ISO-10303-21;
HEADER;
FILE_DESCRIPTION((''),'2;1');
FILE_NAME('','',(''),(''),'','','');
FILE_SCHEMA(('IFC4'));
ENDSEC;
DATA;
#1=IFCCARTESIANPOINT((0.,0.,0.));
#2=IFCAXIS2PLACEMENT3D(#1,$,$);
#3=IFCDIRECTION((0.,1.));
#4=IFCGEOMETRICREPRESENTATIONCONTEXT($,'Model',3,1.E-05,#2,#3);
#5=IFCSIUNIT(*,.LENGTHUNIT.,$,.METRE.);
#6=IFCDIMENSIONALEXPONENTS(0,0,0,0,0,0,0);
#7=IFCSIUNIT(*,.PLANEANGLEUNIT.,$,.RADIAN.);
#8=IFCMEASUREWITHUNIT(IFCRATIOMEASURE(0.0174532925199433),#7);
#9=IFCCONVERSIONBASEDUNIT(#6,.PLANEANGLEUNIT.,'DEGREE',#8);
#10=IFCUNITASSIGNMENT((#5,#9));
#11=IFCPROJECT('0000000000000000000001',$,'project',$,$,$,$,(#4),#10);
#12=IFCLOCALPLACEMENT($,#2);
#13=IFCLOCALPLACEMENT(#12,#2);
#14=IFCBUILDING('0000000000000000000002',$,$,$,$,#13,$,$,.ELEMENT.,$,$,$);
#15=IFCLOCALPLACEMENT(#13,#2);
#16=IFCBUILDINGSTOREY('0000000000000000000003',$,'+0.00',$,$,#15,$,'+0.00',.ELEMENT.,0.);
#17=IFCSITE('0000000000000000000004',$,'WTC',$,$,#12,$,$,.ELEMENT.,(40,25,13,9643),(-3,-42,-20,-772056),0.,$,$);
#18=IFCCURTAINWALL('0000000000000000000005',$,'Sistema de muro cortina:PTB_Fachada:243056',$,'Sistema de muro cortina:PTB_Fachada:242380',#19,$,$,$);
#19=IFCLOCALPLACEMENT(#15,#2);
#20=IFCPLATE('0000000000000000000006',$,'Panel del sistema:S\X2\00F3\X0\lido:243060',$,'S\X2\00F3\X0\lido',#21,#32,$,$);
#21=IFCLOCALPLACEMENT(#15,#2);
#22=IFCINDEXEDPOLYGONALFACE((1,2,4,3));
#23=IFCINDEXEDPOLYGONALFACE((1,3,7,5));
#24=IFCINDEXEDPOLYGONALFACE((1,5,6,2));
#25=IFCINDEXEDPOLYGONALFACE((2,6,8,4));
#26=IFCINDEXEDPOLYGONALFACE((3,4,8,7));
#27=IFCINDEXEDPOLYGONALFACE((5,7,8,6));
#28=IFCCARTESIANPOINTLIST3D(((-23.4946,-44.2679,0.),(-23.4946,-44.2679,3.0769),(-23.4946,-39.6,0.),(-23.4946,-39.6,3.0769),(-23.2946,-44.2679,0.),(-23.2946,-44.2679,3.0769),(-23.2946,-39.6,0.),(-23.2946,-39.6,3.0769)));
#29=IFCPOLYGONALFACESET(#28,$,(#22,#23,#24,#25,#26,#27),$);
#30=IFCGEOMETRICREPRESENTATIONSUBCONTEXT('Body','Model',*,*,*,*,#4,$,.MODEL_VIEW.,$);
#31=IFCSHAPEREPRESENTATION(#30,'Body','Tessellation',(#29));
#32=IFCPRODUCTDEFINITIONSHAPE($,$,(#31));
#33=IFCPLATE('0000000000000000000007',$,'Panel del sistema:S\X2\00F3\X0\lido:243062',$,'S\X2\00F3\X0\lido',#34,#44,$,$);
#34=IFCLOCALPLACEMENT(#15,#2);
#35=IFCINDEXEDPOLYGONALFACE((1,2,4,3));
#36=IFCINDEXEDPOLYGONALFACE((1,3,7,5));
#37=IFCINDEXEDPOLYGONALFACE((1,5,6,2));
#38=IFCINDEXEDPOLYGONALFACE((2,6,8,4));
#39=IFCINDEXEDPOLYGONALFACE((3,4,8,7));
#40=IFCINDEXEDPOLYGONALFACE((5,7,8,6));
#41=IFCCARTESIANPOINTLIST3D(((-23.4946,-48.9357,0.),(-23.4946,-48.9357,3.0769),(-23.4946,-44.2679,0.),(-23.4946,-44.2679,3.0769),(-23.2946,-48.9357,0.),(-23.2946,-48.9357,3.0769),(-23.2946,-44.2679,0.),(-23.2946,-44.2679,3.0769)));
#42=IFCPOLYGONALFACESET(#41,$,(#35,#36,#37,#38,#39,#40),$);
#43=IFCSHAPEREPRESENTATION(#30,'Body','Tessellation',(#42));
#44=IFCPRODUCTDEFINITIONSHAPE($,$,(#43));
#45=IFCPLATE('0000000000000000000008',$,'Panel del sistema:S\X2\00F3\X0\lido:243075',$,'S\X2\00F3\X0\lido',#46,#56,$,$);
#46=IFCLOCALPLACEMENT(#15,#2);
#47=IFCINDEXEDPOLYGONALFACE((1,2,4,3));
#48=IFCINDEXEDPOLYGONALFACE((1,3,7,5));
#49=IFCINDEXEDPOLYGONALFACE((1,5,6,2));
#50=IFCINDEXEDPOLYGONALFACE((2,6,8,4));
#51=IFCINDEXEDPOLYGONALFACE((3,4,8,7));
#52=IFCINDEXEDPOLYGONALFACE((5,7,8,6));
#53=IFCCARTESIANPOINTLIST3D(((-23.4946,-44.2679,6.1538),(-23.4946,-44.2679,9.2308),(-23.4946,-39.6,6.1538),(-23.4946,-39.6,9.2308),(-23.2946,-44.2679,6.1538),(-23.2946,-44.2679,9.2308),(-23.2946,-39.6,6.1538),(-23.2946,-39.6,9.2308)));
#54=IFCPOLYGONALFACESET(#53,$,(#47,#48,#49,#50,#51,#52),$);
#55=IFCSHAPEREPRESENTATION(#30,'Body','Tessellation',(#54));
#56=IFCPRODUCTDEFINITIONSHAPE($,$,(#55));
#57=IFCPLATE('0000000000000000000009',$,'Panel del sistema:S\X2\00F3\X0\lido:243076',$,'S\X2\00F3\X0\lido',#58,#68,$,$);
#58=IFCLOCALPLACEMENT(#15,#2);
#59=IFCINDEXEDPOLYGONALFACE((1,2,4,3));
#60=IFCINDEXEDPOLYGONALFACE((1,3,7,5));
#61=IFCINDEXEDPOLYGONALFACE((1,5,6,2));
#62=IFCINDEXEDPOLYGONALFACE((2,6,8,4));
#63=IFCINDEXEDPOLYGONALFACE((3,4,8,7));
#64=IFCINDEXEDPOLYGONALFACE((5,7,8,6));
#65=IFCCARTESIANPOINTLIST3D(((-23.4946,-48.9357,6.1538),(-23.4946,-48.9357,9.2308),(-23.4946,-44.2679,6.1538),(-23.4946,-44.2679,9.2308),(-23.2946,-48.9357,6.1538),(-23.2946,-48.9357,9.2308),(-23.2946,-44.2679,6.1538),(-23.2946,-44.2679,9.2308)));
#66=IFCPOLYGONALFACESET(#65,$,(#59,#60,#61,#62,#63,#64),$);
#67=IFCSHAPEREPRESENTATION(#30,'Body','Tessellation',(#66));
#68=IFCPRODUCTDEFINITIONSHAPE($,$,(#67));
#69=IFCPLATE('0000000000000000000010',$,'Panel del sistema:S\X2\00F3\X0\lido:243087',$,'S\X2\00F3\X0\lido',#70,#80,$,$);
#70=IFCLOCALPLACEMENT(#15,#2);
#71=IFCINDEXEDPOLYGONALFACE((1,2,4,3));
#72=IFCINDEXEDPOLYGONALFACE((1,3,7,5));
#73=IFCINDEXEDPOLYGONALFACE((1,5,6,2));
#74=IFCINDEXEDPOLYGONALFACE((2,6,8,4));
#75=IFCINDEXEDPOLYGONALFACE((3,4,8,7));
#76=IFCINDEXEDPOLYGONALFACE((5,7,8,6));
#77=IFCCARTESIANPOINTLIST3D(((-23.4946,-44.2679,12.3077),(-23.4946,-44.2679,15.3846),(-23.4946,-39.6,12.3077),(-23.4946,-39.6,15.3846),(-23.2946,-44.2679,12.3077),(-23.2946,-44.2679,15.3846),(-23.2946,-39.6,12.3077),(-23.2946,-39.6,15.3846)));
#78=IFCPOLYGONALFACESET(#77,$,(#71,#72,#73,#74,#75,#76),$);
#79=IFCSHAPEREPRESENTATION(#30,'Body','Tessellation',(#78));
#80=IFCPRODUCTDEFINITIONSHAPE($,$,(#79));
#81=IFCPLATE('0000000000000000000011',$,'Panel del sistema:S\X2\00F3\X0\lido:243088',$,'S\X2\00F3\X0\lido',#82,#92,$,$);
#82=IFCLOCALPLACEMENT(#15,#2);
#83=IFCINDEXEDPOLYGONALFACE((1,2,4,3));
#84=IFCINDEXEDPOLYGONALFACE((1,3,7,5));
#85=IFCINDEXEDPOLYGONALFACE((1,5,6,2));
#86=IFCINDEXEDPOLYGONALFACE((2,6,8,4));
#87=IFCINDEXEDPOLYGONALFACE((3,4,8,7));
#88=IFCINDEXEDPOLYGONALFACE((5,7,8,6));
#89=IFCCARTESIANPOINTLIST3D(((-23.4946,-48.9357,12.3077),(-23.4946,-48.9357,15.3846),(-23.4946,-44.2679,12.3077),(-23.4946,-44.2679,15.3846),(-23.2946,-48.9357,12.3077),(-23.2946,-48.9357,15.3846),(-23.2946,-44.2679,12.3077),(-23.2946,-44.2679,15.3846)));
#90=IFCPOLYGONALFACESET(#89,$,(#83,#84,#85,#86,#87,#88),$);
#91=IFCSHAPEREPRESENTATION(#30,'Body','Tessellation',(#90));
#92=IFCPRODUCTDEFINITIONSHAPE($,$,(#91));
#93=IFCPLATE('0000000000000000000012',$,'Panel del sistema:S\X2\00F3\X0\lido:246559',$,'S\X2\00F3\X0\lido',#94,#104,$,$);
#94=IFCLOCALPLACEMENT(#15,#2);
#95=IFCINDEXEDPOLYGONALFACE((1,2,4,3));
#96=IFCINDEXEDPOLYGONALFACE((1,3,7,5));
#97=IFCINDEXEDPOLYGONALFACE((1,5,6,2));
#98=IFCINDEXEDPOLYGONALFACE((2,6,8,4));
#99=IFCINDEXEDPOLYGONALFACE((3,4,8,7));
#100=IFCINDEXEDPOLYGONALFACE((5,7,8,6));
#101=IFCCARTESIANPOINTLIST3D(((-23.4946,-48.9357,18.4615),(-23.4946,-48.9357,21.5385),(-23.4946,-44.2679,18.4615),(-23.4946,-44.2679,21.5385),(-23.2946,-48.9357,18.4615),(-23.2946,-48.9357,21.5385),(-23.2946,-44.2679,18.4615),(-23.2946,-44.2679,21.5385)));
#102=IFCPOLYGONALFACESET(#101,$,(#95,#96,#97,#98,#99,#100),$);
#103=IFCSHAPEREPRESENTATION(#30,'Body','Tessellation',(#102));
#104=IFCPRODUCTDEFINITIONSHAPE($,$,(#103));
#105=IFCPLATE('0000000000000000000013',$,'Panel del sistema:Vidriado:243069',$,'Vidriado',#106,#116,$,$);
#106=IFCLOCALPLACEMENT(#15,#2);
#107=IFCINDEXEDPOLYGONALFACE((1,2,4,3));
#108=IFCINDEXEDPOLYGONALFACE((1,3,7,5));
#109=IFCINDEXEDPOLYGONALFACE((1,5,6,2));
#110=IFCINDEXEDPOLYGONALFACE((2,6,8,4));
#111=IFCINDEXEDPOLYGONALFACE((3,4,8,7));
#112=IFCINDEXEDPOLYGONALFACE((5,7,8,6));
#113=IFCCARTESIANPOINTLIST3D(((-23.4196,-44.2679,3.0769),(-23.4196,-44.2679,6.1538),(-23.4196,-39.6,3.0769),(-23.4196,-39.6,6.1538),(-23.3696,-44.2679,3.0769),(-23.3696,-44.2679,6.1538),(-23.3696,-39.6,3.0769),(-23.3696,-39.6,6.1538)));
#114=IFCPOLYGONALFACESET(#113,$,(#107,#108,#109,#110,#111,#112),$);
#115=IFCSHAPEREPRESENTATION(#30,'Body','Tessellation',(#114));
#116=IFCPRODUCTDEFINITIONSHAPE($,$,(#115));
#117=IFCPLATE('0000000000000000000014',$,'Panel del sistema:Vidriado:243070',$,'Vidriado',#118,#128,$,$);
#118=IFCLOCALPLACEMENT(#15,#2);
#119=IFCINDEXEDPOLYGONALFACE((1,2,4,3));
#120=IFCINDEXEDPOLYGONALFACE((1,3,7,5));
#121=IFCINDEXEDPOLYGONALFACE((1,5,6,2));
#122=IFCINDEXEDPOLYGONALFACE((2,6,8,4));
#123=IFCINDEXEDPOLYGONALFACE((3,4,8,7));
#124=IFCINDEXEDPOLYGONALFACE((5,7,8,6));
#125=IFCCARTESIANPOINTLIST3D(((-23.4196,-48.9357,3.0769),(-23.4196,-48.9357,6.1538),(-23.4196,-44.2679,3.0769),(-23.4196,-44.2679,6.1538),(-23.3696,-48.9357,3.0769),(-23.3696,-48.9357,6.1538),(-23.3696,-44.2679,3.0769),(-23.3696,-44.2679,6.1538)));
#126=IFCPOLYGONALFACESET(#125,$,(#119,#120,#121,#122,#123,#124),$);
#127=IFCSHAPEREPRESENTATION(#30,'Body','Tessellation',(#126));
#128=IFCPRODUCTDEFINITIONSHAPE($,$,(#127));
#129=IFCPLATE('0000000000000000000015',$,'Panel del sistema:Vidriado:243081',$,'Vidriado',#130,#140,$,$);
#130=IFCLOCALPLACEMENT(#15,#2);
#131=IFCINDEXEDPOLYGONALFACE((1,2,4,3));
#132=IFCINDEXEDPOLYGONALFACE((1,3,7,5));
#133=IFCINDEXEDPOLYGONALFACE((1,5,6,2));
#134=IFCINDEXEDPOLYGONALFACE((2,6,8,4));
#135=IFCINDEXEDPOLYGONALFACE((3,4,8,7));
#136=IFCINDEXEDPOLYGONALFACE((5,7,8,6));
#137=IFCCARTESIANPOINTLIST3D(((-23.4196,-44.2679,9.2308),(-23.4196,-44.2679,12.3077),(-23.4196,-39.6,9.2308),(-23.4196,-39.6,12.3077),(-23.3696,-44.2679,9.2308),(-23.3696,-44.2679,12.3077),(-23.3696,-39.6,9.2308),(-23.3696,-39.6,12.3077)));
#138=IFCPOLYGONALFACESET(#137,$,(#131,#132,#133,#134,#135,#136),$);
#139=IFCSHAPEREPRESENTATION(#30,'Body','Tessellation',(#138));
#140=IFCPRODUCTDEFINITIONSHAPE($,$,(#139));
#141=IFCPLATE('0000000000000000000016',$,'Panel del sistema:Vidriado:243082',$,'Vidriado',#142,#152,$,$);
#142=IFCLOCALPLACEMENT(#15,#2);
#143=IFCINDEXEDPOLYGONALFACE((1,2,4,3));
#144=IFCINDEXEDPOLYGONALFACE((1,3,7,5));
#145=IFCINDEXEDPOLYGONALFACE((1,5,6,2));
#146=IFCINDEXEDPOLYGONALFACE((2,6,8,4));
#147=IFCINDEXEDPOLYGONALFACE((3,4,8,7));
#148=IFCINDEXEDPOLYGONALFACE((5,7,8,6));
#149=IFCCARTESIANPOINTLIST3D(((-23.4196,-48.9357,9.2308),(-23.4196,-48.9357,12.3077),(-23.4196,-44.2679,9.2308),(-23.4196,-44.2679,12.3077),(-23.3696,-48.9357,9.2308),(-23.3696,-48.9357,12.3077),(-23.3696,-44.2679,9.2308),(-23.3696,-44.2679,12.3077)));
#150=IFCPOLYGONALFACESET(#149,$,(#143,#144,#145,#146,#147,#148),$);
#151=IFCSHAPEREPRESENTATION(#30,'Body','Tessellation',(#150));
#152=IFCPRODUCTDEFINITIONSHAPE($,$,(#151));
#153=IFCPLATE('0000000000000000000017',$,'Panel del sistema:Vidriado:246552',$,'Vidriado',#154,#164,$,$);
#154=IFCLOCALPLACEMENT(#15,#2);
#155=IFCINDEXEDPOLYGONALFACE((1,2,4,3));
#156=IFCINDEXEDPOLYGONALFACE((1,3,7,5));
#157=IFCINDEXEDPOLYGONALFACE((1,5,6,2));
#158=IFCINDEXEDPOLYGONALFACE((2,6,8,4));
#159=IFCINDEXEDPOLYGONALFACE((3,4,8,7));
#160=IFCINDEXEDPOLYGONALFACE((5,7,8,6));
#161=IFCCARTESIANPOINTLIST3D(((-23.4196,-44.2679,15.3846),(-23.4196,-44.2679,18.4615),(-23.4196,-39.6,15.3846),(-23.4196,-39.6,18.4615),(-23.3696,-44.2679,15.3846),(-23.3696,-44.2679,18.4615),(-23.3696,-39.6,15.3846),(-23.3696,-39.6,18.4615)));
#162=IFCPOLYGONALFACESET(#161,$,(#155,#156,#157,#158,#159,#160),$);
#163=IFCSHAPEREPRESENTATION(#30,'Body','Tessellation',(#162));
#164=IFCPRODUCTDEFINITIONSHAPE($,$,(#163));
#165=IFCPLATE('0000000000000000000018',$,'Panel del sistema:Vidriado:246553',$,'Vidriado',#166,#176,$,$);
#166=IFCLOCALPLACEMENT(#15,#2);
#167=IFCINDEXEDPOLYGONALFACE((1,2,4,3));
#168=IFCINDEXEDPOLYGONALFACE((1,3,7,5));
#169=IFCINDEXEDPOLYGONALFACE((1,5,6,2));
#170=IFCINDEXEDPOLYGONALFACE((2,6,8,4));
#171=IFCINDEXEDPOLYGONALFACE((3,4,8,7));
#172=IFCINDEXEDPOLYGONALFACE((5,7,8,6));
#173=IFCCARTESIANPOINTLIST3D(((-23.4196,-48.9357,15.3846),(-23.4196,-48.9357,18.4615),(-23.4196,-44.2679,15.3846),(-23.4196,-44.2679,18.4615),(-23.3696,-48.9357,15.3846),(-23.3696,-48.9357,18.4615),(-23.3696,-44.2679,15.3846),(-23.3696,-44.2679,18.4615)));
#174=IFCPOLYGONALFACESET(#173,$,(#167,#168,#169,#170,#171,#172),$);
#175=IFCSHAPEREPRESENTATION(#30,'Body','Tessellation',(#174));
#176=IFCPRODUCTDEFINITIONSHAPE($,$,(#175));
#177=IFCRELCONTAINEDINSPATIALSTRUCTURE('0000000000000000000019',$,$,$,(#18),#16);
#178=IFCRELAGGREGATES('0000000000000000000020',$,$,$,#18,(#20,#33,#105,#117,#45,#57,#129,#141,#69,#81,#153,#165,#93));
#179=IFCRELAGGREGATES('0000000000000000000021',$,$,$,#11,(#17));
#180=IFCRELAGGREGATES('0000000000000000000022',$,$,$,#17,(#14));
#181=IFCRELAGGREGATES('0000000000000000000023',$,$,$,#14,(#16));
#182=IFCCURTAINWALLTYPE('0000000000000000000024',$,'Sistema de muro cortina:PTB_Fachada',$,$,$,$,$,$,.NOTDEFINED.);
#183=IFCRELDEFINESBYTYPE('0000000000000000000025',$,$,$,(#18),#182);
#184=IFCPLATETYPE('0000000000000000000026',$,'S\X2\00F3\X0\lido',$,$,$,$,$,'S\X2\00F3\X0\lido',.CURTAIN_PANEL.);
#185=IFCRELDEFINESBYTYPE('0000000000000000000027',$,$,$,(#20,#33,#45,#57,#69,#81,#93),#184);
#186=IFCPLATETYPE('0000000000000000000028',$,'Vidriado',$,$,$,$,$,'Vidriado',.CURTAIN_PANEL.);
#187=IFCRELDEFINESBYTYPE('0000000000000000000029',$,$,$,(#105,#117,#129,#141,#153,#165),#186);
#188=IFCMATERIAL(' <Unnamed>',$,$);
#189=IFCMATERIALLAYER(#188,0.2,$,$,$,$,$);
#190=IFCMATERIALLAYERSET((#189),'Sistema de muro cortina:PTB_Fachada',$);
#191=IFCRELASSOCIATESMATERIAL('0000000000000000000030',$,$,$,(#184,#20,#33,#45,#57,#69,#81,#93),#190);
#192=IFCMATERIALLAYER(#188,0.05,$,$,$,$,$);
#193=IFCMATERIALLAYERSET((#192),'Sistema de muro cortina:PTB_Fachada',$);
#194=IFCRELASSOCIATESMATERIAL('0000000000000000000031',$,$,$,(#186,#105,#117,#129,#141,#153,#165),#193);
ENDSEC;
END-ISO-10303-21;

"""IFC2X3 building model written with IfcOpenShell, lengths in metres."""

from ifc_helpers import new_model, entity, si_unit, converted_unit, direction, frame, origin, origin_2d_with_axis, place, context, subcontext, project, spatial, rectangle, extrude, source, transform, mapped, material, layer, layer_set, layer_usage, type_object, type_shapes, element, aggregate, save


model = new_model("IFC2X3")

# Units and contexts
model_context = context("Model", 3, precision=1e-05, world=origin(), true_north=direction((0.0, 1.0)))
body_context = subcontext(model_context, "Body", "Model", "MODEL_VIEW")
ifc_project = project(units=[si_unit("LENGTHUNIT", "METRE"), converted_unit("PLANEANGLEUNIT", "DEGREE", entity("IfcRatioMeasure", 0.0174532925199433), si_unit("PLANEANGLEUNIT", "RADIAN"), dimensions=[0, 0, 0, 0, 0, 0, 0])], contexts=[model_context])

# Site, building, storey
site_placement = place(None, origin())
site = spatial("IfcSite", under=ifc_project, at=site_placement, Name="WTC", CompositionType="ELEMENT", RefLatitude=(40, 25, 13, 9643), RefLongitude=(-3, -42, -20, -772056), RefElevation=0.0)
building_placement = place(site_placement, origin())
building = spatial("IfcBuilding", under=site, at=building_placement, CompositionType="ELEMENT")
storey_placement = place(building_placement, origin())
storey = spatial("IfcBuildingStorey", under=building, at=storey_placement, Name="+0.00", LongName="+0.00", CompositionType="ELEMENT", Elevation=0.0)

# Curtain wall, plates
curtain_wall_type = type_object("IfcCurtainWallType", Name="Sistema de muro cortina:PTB_Fachada", PredefinedType="NOTDEFINED")
curtain_wall_1_placement = place(storey_placement, origin())
curtain_wall_1 = element("IfcCurtainWall", 1, at=curtain_wall_1_placement, inside=storey, type_object=curtain_wall_type, Name="Sistema de muro cortina:PTB_Fachada:243056", ObjectType="Sistema de muro cortina:PTB_Fachada:242380")
ifc_material = material(Name=" <Unnamed>")
ifc_layer_1 = layer(ifc_material, 0.2)
ifc_layer_set_1 = layer_set([ifc_layer_1], Name="Sistema de muro cortina:PTB_Fachada")
ifc_layer_usage_1 = layer_usage(ifc_layer_set_1, "AXIS3", "POSITIVE", 0.0)
plate_type_1 = type_object("IfcPlateType", Name="Sólido", ElementType="Sólido", PredefinedType="CURTAIN_PANEL", material=ifc_layer_set_1)
shared_shape_1 = source(origin(), body_context, "Body", "SweptSolid", [
    extrude(rectangle(XDim=0.2, YDim=4.6679, at=origin_2d_with_axis()), frame((0.0, 0.0, 0.0), z_axis=(0.0, 0.0, 1.0), x_axis=(0.0, 1.0, 0.0)), (0.0, 0.0, 1.0), 3.0769),
])
type_shapes(plate_type_1, [shared_shape_1])
plate_1_placement = place(curtain_wall_1_placement, frame((-23.3946, -41.9339, 0.0), z_axis=(0.0, 0.0, 1.0), x_axis=(0.0, -1.0, 0.0)))
plate_1 = element("IfcPlate", 2, at=plate_1_placement, type_object=plate_type_1, material=ifc_layer_usage_1, Name="Panel del sistema:Sólido:243060", ObjectType="Sólido", context=body_context, shape_type="MappedRepresentation", body=[
    mapped(shared_shape_1, transform((0.0, 0.0, 0.0), scale=1.0)),
])
ifc_layer_usage_2 = layer_usage(ifc_layer_set_1, "AXIS3", "POSITIVE", 0.0)
plate_2_placement = place(curtain_wall_1_placement, frame((-23.3946, -46.6018, 0.0), z_axis=(0.0, 0.0, 1.0), x_axis=(0.0, -1.0, 0.0)))
plate_2 = element("IfcPlate", 3, at=plate_2_placement, type_object=plate_type_1, material=ifc_layer_usage_2, Name="Panel del sistema:Sólido:243062", ObjectType="Sólido", context=body_context, shape_type="MappedRepresentation", body=[
    mapped(shared_shape_1, transform((0.0, 0.0, 0.0), scale=1.0)),
])
ifc_layer_usage_3 = layer_usage(ifc_layer_set_1, "AXIS3", "POSITIVE", 0.0)
plate_3_placement = place(curtain_wall_1_placement, frame((-23.3946, -41.9339, 6.1538), z_axis=(0.0, 0.0, 1.0), x_axis=(0.0, -1.0, 0.0)))
plate_3 = element("IfcPlate", 4, at=plate_3_placement, type_object=plate_type_1, material=ifc_layer_usage_3, Name="Panel del sistema:Sólido:243075", ObjectType="Sólido", context=body_context, shape_type="MappedRepresentation", body=[
    mapped(shared_shape_1, transform((0.0, 0.0, 0.0), scale=1.0)),
])
ifc_layer_usage_4 = layer_usage(ifc_layer_set_1, "AXIS3", "POSITIVE", 0.0)
plate_4_placement = place(curtain_wall_1_placement, frame((-23.3946, -46.6018, 6.1538), z_axis=(0.0, 0.0, 1.0), x_axis=(0.0, -1.0, 0.0)))
plate_4 = element("IfcPlate", 5, at=plate_4_placement, type_object=plate_type_1, material=ifc_layer_usage_4, Name="Panel del sistema:Sólido:243076", ObjectType="Sólido", context=body_context, shape_type="MappedRepresentation", body=[
    mapped(shared_shape_1, transform((0.0, 0.0, 0.0), scale=1.0)),
])
ifc_layer_usage_5 = layer_usage(ifc_layer_set_1, "AXIS3", "POSITIVE", 0.0)
plate_5_placement = place(curtain_wall_1_placement, frame((-23.3946, -41.9339, 12.3077), z_axis=(0.0, 0.0, 1.0), x_axis=(0.0, -1.0, 0.0)))
plate_5 = element("IfcPlate", 6, at=plate_5_placement, type_object=plate_type_1, material=ifc_layer_usage_5, Name="Panel del sistema:Sólido:243087", ObjectType="Sólido", context=body_context, shape_type="MappedRepresentation", body=[
    mapped(shared_shape_1, transform((0.0, 0.0, 0.0), scale=1.0)),
])
ifc_layer_usage_6 = layer_usage(ifc_layer_set_1, "AXIS3", "POSITIVE", 0.0)
plate_6_placement = place(curtain_wall_1_placement, frame((-23.3946, -46.6018, 12.3077), z_axis=(0.0, 0.0, 1.0), x_axis=(0.0, -1.0, 0.0)))
plate_6 = element("IfcPlate", 7, at=plate_6_placement, type_object=plate_type_1, material=ifc_layer_usage_6, Name="Panel del sistema:Sólido:243088", ObjectType="Sólido", context=body_context, shape_type="MappedRepresentation", body=[
    mapped(shared_shape_1, transform((0.0, 0.0, 0.0), scale=1.0)),
])
ifc_layer_usage_7 = layer_usage(ifc_layer_set_1, "AXIS3", "POSITIVE", 0.0)
plate_7_placement = place(curtain_wall_1_placement, frame((-23.3946, -46.6018, 18.4615), z_axis=(0.0, 0.0, 1.0), x_axis=(0.0, -1.0, 0.0)))
plate_7 = element("IfcPlate", 8, at=plate_7_placement, type_object=plate_type_1, material=ifc_layer_usage_7, Name="Panel del sistema:Sólido:246559", ObjectType="Sólido", context=body_context, shape_type="MappedRepresentation", body=[
    mapped(shared_shape_1, transform((0.0, 0.0, 0.0), scale=1.0)),
])
ifc_layer_2 = layer(ifc_material, 0.05)
ifc_layer_set_2 = layer_set([ifc_layer_2], Name="Sistema de muro cortina:PTB_Fachada")
ifc_layer_usage_8 = layer_usage(ifc_layer_set_2, "AXIS3", "POSITIVE", 0.0)
plate_type_2 = type_object("IfcPlateType", Name="Vidriado", ElementType="Vidriado", PredefinedType="CURTAIN_PANEL", material=ifc_layer_set_2)
shared_shape_2 = source(origin(), body_context, "Body", "SweptSolid", [
    extrude(rectangle(XDim=0.05, YDim=4.6679, at=origin_2d_with_axis()), frame((0.0, 0.0, 0.0), z_axis=(0.0, 0.0, 1.0), x_axis=(0.0, 1.0, 0.0)), (0.0, 0.0, 1.0), 3.0769),
])
type_shapes(plate_type_2, [shared_shape_2])
plate_8_placement = place(curtain_wall_1_placement, frame((-23.3946, -41.9339, 3.0769), z_axis=(0.0, 0.0, 1.0), x_axis=(0.0, -1.0, 0.0)))
plate_8 = element("IfcPlate", 9, at=plate_8_placement, type_object=plate_type_2, material=ifc_layer_usage_8, Name="Panel del sistema:Vidriado:243069", ObjectType="Vidriado", context=body_context, shape_type="MappedRepresentation", body=[
    mapped(shared_shape_2, transform((0.0, 0.0, 0.0), scale=1.0)),
])
ifc_layer_usage_9 = layer_usage(ifc_layer_set_2, "AXIS3", "POSITIVE", 0.0)
plate_9_placement = place(curtain_wall_1_placement, frame((-23.3946, -46.6018, 3.0769), z_axis=(0.0, 0.0, 1.0), x_axis=(0.0, -1.0, 0.0)))
plate_9 = element("IfcPlate", 10, at=plate_9_placement, type_object=plate_type_2, material=ifc_layer_usage_9, Name="Panel del sistema:Vidriado:243070", ObjectType="Vidriado", context=body_context, shape_type="MappedRepresentation", body=[
    mapped(shared_shape_2, transform((0.0, 0.0, 0.0), scale=1.0)),
])
ifc_layer_usage_10 = layer_usage(ifc_layer_set_2, "AXIS3", "POSITIVE", 0.0)
plate_10_placement = place(curtain_wall_1_placement, frame((-23.3946, -41.9339, 9.2308), z_axis=(0.0, 0.0, 1.0), x_axis=(0.0, -1.0, 0.0)))
plate_10 = element("IfcPlate", 11, at=plate_10_placement, type_object=plate_type_2, material=ifc_layer_usage_10, Name="Panel del sistema:Vidriado:243081", ObjectType="Vidriado", context=body_context, shape_type="MappedRepresentation", body=[
    mapped(shared_shape_2, transform((0.0, 0.0, 0.0), scale=1.0)),
])
ifc_layer_usage_11 = layer_usage(ifc_layer_set_2, "AXIS3", "POSITIVE", 0.0)
plate_11_placement = place(curtain_wall_1_placement, frame((-23.3946, -46.6018, 9.2308), z_axis=(0.0, 0.0, 1.0), x_axis=(0.0, -1.0, 0.0)))
plate_11 = element("IfcPlate", 12, at=plate_11_placement, type_object=plate_type_2, material=ifc_layer_usage_11, Name="Panel del sistema:Vidriado:243082", ObjectType="Vidriado", context=body_context, shape_type="MappedRepresentation", body=[
    mapped(shared_shape_2, transform((0.0, 0.0, 0.0), scale=1.0)),
])
ifc_layer_usage_12 = layer_usage(ifc_layer_set_2, "AXIS3", "POSITIVE", 0.0)
plate_12_placement = place(curtain_wall_1_placement, frame((-23.3946, -41.9339, 15.3846), z_axis=(0.0, 0.0, 1.0), x_axis=(0.0, -1.0, 0.0)))
plate_12 = element("IfcPlate", 13, at=plate_12_placement, type_object=plate_type_2, material=ifc_layer_usage_12, Name="Panel del sistema:Vidriado:246552", ObjectType="Vidriado", context=body_context, shape_type="MappedRepresentation", body=[
    mapped(shared_shape_2, transform((0.0, 0.0, 0.0), scale=1.0)),
])
ifc_layer_usage_13 = layer_usage(ifc_layer_set_2, "AXIS3", "POSITIVE", 0.0)
plate_13_placement = place(curtain_wall_1_placement, frame((-23.3946, -46.6018, 15.3846), z_axis=(0.0, 0.0, 1.0), x_axis=(0.0, -1.0, 0.0)))
plate_13 = element("IfcPlate", 14, at=plate_13_placement, type_object=plate_type_2, material=ifc_layer_usage_13, Name="Panel del sistema:Vidriado:246553", ObjectType="Vidriado", context=body_context, shape_type="MappedRepresentation", body=[
    mapped(shared_shape_2, transform((0.0, 0.0, 0.0), scale=1.0)),
])
aggregate(curtain_wall_1, [plate_1, plate_2, plate_8, plate_9, plate_3, plate_4, plate_10, plate_11, plate_5, plate_6, plate_12, plate_13, plate_7])

save(model, "model.ifc")
